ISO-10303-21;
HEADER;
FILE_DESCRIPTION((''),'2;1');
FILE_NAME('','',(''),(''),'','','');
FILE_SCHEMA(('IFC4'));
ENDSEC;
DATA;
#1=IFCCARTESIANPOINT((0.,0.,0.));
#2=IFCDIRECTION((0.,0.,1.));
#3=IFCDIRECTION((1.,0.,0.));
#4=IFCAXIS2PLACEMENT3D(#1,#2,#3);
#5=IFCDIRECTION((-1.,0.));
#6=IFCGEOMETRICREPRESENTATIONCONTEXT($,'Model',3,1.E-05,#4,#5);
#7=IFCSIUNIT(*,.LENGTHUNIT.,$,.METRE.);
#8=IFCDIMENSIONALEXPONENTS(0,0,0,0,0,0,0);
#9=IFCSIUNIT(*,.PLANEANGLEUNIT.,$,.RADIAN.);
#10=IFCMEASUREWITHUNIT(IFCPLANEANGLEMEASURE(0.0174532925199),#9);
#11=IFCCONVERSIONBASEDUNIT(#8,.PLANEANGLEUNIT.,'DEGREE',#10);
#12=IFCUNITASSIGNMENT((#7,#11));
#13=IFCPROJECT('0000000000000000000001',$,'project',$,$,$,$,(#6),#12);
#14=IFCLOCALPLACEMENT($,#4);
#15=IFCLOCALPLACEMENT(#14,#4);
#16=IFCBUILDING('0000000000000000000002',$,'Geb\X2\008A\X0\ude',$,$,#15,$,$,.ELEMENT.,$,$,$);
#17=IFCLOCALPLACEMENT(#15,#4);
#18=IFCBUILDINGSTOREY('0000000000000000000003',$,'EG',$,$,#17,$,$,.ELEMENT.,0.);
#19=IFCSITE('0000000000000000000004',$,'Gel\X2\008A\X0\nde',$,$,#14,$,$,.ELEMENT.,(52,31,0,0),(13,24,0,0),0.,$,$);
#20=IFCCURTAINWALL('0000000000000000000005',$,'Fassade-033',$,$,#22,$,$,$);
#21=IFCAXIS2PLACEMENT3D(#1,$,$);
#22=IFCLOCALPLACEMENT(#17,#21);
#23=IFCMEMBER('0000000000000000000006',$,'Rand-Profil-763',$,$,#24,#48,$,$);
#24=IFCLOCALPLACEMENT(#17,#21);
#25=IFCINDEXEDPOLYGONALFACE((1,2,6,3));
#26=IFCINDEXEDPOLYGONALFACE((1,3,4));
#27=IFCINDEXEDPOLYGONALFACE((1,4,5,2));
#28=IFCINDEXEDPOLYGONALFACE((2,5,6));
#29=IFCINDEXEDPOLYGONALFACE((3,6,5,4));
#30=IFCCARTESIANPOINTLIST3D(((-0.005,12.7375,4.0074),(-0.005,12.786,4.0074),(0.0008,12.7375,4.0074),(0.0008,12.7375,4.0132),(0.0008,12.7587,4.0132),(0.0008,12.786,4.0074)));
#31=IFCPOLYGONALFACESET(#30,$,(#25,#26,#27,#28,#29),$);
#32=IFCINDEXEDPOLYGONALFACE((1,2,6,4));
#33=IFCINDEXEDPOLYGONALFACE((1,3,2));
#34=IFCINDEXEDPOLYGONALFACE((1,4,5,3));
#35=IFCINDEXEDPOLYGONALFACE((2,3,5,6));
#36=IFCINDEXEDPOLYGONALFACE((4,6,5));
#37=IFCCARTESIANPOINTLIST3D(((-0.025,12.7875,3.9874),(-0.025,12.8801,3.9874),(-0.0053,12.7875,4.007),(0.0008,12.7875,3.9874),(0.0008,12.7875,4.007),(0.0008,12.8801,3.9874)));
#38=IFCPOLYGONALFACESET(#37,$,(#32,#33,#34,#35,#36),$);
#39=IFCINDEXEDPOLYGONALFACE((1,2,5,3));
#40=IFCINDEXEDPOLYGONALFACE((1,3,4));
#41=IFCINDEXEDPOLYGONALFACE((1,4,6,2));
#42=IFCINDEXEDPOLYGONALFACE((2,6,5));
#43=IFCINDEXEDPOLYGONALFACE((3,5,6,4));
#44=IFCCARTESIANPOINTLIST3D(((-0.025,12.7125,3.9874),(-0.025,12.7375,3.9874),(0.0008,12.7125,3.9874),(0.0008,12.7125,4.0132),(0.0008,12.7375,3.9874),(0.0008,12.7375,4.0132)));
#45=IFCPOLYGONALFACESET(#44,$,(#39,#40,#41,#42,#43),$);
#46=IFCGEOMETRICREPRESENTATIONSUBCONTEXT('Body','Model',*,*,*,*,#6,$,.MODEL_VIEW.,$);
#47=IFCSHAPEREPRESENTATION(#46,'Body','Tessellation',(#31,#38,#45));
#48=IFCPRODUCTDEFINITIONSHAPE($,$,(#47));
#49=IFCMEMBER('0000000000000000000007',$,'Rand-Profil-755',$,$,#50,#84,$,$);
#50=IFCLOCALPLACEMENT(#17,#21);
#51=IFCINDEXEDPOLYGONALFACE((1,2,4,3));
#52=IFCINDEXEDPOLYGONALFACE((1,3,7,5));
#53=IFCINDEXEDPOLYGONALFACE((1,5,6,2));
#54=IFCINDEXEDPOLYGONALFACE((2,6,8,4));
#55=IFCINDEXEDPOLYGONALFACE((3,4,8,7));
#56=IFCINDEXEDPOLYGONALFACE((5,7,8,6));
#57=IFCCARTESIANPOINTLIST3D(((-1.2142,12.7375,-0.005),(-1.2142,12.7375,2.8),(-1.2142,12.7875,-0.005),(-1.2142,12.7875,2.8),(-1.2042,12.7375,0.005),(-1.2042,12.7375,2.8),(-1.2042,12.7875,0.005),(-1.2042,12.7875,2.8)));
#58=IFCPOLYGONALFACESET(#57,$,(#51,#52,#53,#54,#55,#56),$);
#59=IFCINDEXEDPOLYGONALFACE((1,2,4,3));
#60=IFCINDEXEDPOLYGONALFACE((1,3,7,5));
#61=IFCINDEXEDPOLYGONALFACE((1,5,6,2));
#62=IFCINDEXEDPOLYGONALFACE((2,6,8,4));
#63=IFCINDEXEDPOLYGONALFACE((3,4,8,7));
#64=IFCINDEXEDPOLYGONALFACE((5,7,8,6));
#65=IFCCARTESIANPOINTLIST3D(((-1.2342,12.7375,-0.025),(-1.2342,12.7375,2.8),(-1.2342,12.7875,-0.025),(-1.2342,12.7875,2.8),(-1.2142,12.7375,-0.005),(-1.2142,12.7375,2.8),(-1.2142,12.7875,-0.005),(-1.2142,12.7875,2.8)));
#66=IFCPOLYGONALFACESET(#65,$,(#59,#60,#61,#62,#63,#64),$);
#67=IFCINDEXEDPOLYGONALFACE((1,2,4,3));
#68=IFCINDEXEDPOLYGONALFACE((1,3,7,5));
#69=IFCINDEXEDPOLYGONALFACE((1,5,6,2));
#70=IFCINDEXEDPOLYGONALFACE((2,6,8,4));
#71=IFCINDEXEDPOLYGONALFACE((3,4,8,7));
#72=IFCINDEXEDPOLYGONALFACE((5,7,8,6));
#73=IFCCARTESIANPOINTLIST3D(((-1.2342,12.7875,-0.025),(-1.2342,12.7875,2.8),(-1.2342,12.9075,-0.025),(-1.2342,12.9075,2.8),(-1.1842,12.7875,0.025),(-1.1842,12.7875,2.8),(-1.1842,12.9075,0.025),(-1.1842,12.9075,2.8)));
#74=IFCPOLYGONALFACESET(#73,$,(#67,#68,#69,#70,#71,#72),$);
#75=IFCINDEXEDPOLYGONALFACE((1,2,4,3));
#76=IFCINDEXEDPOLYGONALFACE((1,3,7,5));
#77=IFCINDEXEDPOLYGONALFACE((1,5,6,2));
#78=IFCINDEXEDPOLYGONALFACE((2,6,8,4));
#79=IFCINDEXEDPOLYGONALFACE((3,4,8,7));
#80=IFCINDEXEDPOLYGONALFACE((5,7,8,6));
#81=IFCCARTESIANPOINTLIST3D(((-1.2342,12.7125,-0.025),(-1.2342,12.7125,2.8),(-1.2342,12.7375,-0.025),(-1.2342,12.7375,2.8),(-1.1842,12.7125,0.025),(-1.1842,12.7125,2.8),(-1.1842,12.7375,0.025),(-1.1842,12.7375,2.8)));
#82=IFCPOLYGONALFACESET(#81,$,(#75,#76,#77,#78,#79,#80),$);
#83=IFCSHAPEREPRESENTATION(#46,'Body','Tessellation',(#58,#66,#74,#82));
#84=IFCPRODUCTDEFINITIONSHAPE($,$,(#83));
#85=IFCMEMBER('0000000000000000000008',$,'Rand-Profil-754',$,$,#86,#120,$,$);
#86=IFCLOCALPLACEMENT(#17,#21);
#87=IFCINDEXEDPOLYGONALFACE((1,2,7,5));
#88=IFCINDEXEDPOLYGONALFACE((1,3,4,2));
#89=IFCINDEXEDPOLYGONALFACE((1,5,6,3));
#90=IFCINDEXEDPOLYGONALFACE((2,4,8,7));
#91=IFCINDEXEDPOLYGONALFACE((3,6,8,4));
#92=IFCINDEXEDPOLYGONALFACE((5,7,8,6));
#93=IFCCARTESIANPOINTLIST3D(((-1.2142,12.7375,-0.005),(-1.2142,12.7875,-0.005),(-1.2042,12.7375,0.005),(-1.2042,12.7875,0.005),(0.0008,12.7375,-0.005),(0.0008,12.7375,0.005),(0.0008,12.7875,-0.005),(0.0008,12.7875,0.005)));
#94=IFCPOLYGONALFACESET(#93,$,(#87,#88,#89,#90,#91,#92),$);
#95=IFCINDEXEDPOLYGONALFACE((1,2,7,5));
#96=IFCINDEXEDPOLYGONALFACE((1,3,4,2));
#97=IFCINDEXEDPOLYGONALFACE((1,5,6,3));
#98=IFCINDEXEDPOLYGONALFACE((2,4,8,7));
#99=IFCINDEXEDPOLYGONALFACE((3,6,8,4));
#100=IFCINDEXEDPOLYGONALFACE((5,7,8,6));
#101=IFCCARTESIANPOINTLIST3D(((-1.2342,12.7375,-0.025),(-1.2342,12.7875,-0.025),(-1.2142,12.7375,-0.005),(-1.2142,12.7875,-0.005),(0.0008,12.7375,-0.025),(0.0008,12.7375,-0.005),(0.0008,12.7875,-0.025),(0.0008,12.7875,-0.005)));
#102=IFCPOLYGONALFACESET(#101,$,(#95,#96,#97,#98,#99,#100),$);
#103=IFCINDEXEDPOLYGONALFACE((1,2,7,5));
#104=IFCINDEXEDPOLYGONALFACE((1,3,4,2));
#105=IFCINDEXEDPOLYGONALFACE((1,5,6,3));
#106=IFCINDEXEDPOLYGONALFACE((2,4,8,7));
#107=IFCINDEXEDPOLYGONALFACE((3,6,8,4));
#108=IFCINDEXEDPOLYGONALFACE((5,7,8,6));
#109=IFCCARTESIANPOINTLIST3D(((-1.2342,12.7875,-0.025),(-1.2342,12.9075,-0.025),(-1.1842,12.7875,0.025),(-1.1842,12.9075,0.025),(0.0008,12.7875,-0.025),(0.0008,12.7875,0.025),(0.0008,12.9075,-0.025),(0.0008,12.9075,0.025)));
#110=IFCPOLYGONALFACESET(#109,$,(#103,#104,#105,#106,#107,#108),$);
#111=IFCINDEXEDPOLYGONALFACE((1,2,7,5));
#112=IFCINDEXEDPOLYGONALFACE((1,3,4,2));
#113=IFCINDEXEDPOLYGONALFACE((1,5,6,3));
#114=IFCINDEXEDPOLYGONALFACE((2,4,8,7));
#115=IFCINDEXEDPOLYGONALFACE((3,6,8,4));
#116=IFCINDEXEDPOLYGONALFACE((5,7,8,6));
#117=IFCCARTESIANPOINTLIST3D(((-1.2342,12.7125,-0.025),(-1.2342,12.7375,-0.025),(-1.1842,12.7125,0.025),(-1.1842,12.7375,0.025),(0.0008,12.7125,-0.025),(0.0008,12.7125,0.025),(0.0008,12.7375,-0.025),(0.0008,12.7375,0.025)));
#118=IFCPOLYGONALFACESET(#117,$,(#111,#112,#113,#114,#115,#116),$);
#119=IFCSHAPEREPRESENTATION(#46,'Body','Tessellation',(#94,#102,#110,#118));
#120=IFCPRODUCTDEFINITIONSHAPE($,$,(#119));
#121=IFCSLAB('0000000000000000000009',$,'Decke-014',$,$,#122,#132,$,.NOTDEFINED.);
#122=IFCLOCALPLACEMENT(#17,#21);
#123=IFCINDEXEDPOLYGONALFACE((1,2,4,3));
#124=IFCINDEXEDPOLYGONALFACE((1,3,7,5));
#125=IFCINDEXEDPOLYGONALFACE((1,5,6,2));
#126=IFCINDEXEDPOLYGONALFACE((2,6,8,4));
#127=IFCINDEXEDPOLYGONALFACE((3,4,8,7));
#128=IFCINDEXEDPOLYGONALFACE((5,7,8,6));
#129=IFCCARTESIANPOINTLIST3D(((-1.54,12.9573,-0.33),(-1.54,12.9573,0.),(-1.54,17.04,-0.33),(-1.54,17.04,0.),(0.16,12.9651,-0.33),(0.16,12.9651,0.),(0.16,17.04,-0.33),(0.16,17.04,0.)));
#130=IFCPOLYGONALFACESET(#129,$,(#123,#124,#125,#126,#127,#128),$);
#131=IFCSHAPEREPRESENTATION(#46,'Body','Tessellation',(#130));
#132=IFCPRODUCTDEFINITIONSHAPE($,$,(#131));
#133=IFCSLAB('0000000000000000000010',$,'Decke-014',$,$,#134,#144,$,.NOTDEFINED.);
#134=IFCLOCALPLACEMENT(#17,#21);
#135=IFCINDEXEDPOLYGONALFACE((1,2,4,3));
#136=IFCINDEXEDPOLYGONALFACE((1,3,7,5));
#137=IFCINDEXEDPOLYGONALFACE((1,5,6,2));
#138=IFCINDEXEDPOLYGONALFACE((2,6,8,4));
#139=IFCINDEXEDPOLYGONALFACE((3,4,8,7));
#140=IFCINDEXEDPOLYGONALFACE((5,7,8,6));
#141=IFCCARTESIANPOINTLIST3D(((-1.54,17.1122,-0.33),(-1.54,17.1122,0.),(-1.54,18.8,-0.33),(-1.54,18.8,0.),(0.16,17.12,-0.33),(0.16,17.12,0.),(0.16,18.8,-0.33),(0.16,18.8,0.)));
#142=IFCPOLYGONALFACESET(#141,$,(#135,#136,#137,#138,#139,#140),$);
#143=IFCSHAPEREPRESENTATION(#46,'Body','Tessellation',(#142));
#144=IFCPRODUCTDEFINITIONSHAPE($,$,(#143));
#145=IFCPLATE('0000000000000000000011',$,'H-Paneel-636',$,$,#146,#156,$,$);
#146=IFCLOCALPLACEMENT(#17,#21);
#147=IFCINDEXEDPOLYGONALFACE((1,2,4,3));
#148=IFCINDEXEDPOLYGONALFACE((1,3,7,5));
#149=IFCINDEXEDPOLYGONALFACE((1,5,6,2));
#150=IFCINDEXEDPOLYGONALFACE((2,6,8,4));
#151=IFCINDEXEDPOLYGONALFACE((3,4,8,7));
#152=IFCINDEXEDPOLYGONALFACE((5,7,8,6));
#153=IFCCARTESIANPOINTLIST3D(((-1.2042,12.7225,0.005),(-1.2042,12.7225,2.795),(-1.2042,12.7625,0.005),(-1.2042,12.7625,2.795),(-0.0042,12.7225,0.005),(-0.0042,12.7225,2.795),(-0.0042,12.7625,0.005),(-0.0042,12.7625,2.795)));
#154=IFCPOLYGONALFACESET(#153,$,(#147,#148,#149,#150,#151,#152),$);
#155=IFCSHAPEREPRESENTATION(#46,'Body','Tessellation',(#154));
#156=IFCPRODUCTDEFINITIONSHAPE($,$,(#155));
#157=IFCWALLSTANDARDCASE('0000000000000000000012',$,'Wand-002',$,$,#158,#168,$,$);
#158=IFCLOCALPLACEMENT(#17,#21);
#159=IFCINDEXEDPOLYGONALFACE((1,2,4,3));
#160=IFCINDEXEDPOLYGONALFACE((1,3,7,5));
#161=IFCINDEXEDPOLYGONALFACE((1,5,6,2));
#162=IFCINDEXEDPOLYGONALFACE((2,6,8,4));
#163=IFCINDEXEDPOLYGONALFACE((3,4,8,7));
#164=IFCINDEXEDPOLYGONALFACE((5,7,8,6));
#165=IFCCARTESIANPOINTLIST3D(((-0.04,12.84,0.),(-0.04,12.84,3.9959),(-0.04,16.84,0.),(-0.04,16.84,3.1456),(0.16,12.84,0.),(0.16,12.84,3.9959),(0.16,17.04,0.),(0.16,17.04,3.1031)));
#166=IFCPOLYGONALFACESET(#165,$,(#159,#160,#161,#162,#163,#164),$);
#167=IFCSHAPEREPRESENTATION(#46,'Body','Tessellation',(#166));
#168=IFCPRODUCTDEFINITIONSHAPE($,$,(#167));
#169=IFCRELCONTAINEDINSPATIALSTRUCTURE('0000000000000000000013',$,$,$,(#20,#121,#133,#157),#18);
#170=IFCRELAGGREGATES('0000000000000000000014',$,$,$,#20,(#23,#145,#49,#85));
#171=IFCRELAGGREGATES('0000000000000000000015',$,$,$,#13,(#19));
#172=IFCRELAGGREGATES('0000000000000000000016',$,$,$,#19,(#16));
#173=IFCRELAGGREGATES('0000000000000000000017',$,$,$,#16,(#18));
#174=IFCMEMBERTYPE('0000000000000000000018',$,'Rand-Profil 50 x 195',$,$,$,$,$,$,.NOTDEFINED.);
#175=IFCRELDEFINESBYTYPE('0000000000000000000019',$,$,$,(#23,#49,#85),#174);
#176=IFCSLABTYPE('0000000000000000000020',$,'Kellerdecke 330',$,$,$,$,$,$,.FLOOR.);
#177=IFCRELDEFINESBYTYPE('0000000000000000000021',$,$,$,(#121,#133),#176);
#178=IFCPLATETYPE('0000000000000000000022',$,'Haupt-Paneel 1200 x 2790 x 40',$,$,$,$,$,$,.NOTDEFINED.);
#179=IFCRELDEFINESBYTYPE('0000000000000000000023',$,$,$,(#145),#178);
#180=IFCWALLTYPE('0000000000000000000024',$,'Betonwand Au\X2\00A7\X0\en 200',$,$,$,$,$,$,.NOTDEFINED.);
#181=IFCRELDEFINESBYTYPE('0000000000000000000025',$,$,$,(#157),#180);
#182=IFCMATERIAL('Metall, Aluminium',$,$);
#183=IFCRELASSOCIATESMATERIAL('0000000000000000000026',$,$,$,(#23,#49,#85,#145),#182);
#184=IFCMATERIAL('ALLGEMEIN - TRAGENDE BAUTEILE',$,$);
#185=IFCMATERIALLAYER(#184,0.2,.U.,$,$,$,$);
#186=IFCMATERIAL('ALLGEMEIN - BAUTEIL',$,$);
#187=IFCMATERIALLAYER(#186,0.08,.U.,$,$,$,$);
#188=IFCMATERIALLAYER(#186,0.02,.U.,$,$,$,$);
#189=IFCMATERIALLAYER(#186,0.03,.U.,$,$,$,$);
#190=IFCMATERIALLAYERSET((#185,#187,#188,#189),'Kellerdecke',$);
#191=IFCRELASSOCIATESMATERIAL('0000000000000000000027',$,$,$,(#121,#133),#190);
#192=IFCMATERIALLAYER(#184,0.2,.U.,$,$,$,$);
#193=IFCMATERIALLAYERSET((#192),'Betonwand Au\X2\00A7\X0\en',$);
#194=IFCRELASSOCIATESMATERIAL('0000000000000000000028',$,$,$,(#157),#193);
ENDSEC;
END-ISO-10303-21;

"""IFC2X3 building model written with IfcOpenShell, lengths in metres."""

from ifc_helpers import new_model, entity, si_unit, converted_unit, direction, frame, origin_with_axes, place, context, subcontext, project, spatial, polyline, outline, extrude, clip, halfspace, material, layer, layer_set, layer_usage, type_object, element, aggregate, save


model = new_model("IFC2X3")

# Units and contexts
model_context = context("Model", 3, precision=1e-05, world=origin_with_axes(), true_north=direction((-1.0, 0.0)))
body_context = subcontext(model_context, "Body", "Model", "MODEL_VIEW")
ifc_project = project(units=[si_unit("LENGTHUNIT", "METRE"), converted_unit("PLANEANGLEUNIT", "DEGREE", entity("IfcPlaneAngleMeasure", 0.0174532925199), si_unit("PLANEANGLEUNIT", "RADIAN"), dimensions=[0, 0, 0, 0, 0, 0, 0])], contexts=[model_context])

# Site, building, storey
site_placement = place(None, origin_with_axes())
site = spatial("IfcSite", under=ifc_project, at=site_placement, Name="Gel\u008ande", CompositionType="ELEMENT", RefLatitude=(52, 31, 0, 0), RefLongitude=(13, 24, 0, 0), RefElevation=0.0)
building_placement = place(site_placement, origin_with_axes())
building = spatial("IfcBuilding", under=site, at=building_placement, Name="Geb\u008aude", CompositionType="ELEMENT")
storey_placement = place(building_placement, origin_with_axes())
storey = spatial("IfcBuildingStorey", under=building, at=storey_placement, Name="EG", CompositionType="ELEMENT", Elevation=0.0)

# Curtain wall, members
curtain_wall_placement = place(storey_placement, frame((-0.6042, 12.7625, 0.0), z_axis=(0.0, 0.0, 1.0), x_axis=(1.0, 0.0, 0.0)))
curtain_wall = element("IfcCurtainWall", 1, at=curtain_wall_placement, inside=storey, Name="Fassade-033")
ifc_material_1 = material(Name="Metall, Aluminium")
member_type_1 = type_object("IfcMemberType", Name="Rand-Profil 50 x 195", PredefinedType="NOTDEFINED")
member_1_placement = place(curtain_wall_placement, frame((0.605, 0.0, 4.0124), z_axis=(-1.0, 0.0, 0.0), x_axis=(0.0, 0.0, -1.0)))
member_1 = element("IfcMember", 2, at=member_1_placement, type_object=member_type_1, material=ifc_material_1, Name="Rand-Profil-763", context=body_context, shape_type="Clipping", body=[
    clip(extrude(outline(polyline([(-0.0038, -0.0008), (0.0235, 0.005), (-0.025, 0.005), (-0.025, -0.0008), (-0.0038, -0.0008)])), frame((0.0, 0.0, 0.0), z_axis=(0.0, 0.0, 1.0), x_axis=(0.0, -1.0, 0.0)), (0.0, 0.0, 1.0), 0.0058), halfspace(frame((-0.0004, 0.0, 0.0004), z_axis=(0.707107, 0.0, -0.707107), x_axis=(0.707107, 0.0, 0.707107)), True)),
    clip(extrude(outline(polyline([(0.025, 0.0053), (0.1176, 0.025), (0.025, 0.025), (0.025, 0.0053)])), frame((0.0, 0.0, 0.0), z_axis=(0.0, 0.0, 1.0), x_axis=(0.0, -1.0, 0.0)), (0.0, 0.0, 1.0), 0.0258), halfspace(frame((-0.0004, 0.0, 0.0004), z_axis=(0.707107, 0.0, -0.707107), x_axis=(0.707107, 0.0, 0.707107)), True)),
    clip(extrude(outline(polyline([(-0.025, -0.0008), (-0.025, 0.025), (-0.05, 0.025), (-0.05, -0.0008), (-0.025, -0.0008)])), frame((0.0, 0.0, 0.0), z_axis=(0.0, 0.0, 1.0), x_axis=(0.0, -1.0, 0.0)), (0.0, 0.0, 1.0), 0.0258), halfspace(frame((-0.0004, 0.0, 0.0004), z_axis=(0.707107, 0.0, -0.707107), x_axis=(0.707107, 0.0, 0.707107)), True)),
])
member_2_placement = place(curtain_wall_placement, frame((-0.605, 0.0, 0.0), z_axis=(0.0, 0.0, 1.0), x_axis=(-1.0, 0.0, 0.0)))
member_2 = element("IfcMember", 3, at=member_2_placement, type_object=member_type_1, material=ifc_material_1, Name="Rand-Profil-755", context=body_context, shape_type="Clipping", body=[
    clip(extrude(outline(polyline([(-0.005, 0.025), (-0.005, -0.025), (0.005, -0.025), (0.005, 0.025), (-0.005, 0.025)])), frame((0.0, 0.0, -0.005), z_axis=(0.0, 0.0, 1.0), x_axis=(-1.0, 0.0, 0.0)), (0.0, 0.0, 1.0), 2.805), halfspace(frame((0.0, 0.0, 0.0), z_axis=(0.707107, 0.0, 0.707107), x_axis=(-0.707107, 0.0, 0.707107)), True)),
    clip(extrude(outline(polyline([(-0.025, 0.025), (-0.025, -0.025), (-0.005, -0.025), (-0.005, 0.025), (-0.025, 0.025)])), frame((0.0, 0.0, -0.025), z_axis=(0.0, 0.0, 1.0), x_axis=(-1.0, 0.0, 0.0)), (0.0, 0.0, 1.0), 2.825), halfspace(frame((0.0, 0.0, 0.0), z_axis=(0.707107, 0.0, 0.707107), x_axis=(-0.707107, 0.0, 0.707107)), True)),
    clip(extrude(outline(polyline([(-0.025, 0.145), (-0.025, 0.025), (0.025, 0.025), (0.025, 0.145), (-0.025, 0.145)])), frame((0.0, 0.0, -0.025), z_axis=(0.0, 0.0, 1.0), x_axis=(-1.0, 0.0, 0.0)), (0.0, 0.0, 1.0), 2.825), halfspace(frame((0.0, 0.0, 0.0), z_axis=(0.707107, 0.0, 0.707107), x_axis=(-0.707107, 0.0, 0.707107)), True)),
    clip(extrude(outline(polyline([(0.025, -0.05), (0.025, -0.025), (-0.025, -0.025), (-0.025, -0.05), (0.025, -0.05)])), frame((0.0, 0.0, -0.025), z_axis=(0.0, 0.0, 1.0), x_axis=(-1.0, 0.0, 0.0)), (0.0, 0.0, 1.0), 2.825), halfspace(frame((0.0, 0.0, 0.0), z_axis=(0.707107, 0.0, 0.707107), x_axis=(-0.707107, 0.0, 0.707107)), True)),
])
member_3_placement = place(curtain_wall_placement, frame((-0.605, 0.0, 0.0), z_axis=(1.0, 0.0, 0.0), x_axis=(0.0, 0.0, 1.0)))
member_3 = element("IfcMember", 4, at=member_3_placement, type_object=member_type_1, material=ifc_material_1, Name="Rand-Profil-754", context=body_context, shape_type="Clipping", body=[
    clip(extrude(outline(polyline([(-0.025, -0.005), (0.025, -0.005), (0.025, 0.005), (-0.025, 0.005), (-0.025, -0.005)])), frame((0.0, 0.0, -0.005), z_axis=(0.0, 0.0, 1.0), x_axis=(0.0, 1.0, 0.0)), (0.0, 0.0, 1.0), 1.215), halfspace(frame((0.0, 0.0, 0.0), z_axis=(-0.707107, 0.0, 0.707107), x_axis=(-0.707107, 0.0, -0.707107)), True)),
    clip(extrude(outline(polyline([(-0.025, 0.005), (0.025, 0.005), (0.025, 0.025), (-0.025, 0.025), (-0.025, 0.005)])), frame((0.0, 0.0, -0.025), z_axis=(0.0, 0.0, 1.0), x_axis=(0.0, 1.0, 0.0)), (0.0, 0.0, 1.0), 1.235), halfspace(frame((0.0, 0.0, 0.0), z_axis=(-0.707107, 0.0, 0.707107), x_axis=(-0.707107, 0.0, -0.707107)), True)),
    clip(extrude(outline(polyline([(-0.145, -0.025), (-0.025, -0.025), (-0.025, 0.025), (-0.145, 0.025), (-0.145, -0.025)])), frame((0.0, 0.0, -0.025), z_axis=(0.0, 0.0, 1.0), x_axis=(0.0, 1.0, 0.0)), (0.0, 0.0, 1.0), 1.235), halfspace(frame((0.0, 0.0, 0.0), z_axis=(-0.707107, 0.0, 0.707107), x_axis=(-0.707107, 0.0, -0.707107)), True)),
    clip(extrude(outline(polyline([(0.05, 0.025), (0.025, 0.025), (0.025, -0.025), (0.05, -0.025), (0.05, 0.025)])), frame((0.0, 0.0, -0.025), z_axis=(0.0, 0.0, 1.0), x_axis=(0.0, 1.0, 0.0)), (0.0, 0.0, 1.0), 1.235), halfspace(frame((0.0, 0.0, 0.0), z_axis=(-0.707107, 0.0, 0.707107), x_axis=(-0.707107, 0.0, -0.707107)), True)),
])

# Slabs
ifc_material_2 = material(Name="ALLGEMEIN - TRAGENDE BAUTEILE")
ifc_layer_1 = layer(ifc_material_2, 0.2, ventilated="UNKNOWN")
ifc_material_3 = material(Name="ALLGEMEIN - BAUTEIL")
ifc_layer_2 = layer(ifc_material_3, 0.08, ventilated="UNKNOWN")
ifc_layer_3 = layer(ifc_material_3, 0.02, ventilated="UNKNOWN")
ifc_layer_4 = layer(ifc_material_3, 0.03, ventilated="UNKNOWN")
ifc_layer_set_1 = layer_set([ifc_layer_1, ifc_layer_2, ifc_layer_3, ifc_layer_4], Name="Kellerdecke")
ifc_layer_usage_1 = layer_usage(ifc_layer_set_1, "AXIS3", "NEGATIVE", 0.33)
slab_type = type_object("IfcSlabType", Name="Kellerdecke 330", PredefinedType="FLOOR")
slab_1_placement = place(storey_placement, frame((-1.54, 17.04, 0.0), z_axis=(0.0, 0.0, 1.0), x_axis=(1.0, 0.0, 0.0)))
element("IfcSlab", 5, at=slab_1_placement, inside=storey, type_object=slab_type, material=ifc_layer_usage_1, Name="Decke-014", PredefinedType="NOTDEFINED", context=body_context, shape_type="SweptSolid", body=[
    extrude(outline(polyline([(0.0, 0.0), (0.0, -4.0827), (1.7, -4.0749), (1.7, 0.0), (0.0, 0.0)])), frame((0.0, 0.0, -0.33), z_axis=(0.0, 0.0, 1.0), x_axis=(1.0, 0.0, 0.0)), (0.0, 0.0, 1.0), 0.33),
])
ifc_layer_usage_2 = layer_usage(ifc_layer_set_1, "AXIS3", "NEGATIVE", 0.33)
slab_2_placement = place(storey_placement, frame((-1.54, 18.8, 0.0), z_axis=(0.0, 0.0, 1.0), x_axis=(1.0, 0.0, 0.0)))
element("IfcSlab", 6, at=slab_2_placement, inside=storey, type_object=slab_type, material=ifc_layer_usage_2, Name="Decke-014", PredefinedType="NOTDEFINED", context=body_context, shape_type="SweptSolid", body=[
    extrude(outline(polyline([(0.0, 0.0), (0.0, -1.6878), (1.7, -1.68), (1.7, 0.0), (0.0, 0.0)])), frame((0.0, 0.0, -0.33), z_axis=(0.0, 0.0, 1.0), x_axis=(1.0, 0.0, 0.0)), (0.0, 0.0, 1.0), 0.33),
])

# Plate
plate_type_1 = type_object("IfcPlateType", Name="Haupt-Paneel 1200 x 2790 x 40", PredefinedType="NOTDEFINED")
plate_1_placement = place(curtain_wall_placement, frame((0.0, 0.0, 1.4), z_axis=(0.0, 0.0, 1.0), x_axis=(-1.0, 0.0, 0.0)))
plate_1 = element("IfcPlate", 7, at=plate_1_placement, type_object=plate_type_1, material=ifc_material_1, Name="H-Paneel-636", context=body_context, shape_type="SweptSolid", body=[
    extrude(outline(polyline([(0.005, 0.005), (1.205, 0.005), (1.205, 2.795), (0.005, 2.795), (0.005, 0.005)])), frame((0.605, 0.0, -1.4), z_axis=(0.0, 1.0, 0.0), x_axis=(-1.0, 0.0, 0.0)), (0.0, 0.0, 1.0), 0.04),
])
aggregate(curtain_wall, [member_1, plate_1, member_2, member_3])

# Wall
ifc_layer_5 = layer(ifc_material_2, 0.2, ventilated="UNKNOWN")
ifc_layer_set_2 = layer_set([ifc_layer_5], Name="Betonwand Au§en")
wall_type = type_object("IfcWallType", Name="Betonwand Au§en 200", PredefinedType="NOTDEFINED")
ifc_layer_usage_3 = layer_usage(ifc_layer_set_2, "AXIS2", "NEGATIVE", 0.0)
wall_1_placement = place(storey_placement, frame((-0.04, 12.84, 0.0), z_axis=(0.0, 0.0, 1.0), x_axis=(0.0, 1.0, 0.0)))
element("IfcWallStandardCase", 8, at=wall_1_placement, inside=storey, type_object=wall_type, material=ifc_layer_usage_3, Name="Wand-002", context=body_context, shape_type="Clipping", body=[
    clip(clip(extrude(outline(polyline([(0.0, -0.2), (4.2, -0.2), (4.0, 0.0), (0.0, 0.0), (0.0, -0.2)])), origin_with_axes(), (0.0, 0.0, 1.0), 6.0), halfspace(frame((0.8126, 0.0, 3.8231), z_axis=(-0.207912, 0.0, -0.978148), x_axis=(0.978148, 0.0, -0.207912)), True)), halfspace(frame((0.9756, 0.0, 4.5899), z_axis=(-0.207912, 0.0, -0.978148), x_axis=(0.978148, 0.0, -0.207912)), True)),
])

save(model, "model.ifc")
